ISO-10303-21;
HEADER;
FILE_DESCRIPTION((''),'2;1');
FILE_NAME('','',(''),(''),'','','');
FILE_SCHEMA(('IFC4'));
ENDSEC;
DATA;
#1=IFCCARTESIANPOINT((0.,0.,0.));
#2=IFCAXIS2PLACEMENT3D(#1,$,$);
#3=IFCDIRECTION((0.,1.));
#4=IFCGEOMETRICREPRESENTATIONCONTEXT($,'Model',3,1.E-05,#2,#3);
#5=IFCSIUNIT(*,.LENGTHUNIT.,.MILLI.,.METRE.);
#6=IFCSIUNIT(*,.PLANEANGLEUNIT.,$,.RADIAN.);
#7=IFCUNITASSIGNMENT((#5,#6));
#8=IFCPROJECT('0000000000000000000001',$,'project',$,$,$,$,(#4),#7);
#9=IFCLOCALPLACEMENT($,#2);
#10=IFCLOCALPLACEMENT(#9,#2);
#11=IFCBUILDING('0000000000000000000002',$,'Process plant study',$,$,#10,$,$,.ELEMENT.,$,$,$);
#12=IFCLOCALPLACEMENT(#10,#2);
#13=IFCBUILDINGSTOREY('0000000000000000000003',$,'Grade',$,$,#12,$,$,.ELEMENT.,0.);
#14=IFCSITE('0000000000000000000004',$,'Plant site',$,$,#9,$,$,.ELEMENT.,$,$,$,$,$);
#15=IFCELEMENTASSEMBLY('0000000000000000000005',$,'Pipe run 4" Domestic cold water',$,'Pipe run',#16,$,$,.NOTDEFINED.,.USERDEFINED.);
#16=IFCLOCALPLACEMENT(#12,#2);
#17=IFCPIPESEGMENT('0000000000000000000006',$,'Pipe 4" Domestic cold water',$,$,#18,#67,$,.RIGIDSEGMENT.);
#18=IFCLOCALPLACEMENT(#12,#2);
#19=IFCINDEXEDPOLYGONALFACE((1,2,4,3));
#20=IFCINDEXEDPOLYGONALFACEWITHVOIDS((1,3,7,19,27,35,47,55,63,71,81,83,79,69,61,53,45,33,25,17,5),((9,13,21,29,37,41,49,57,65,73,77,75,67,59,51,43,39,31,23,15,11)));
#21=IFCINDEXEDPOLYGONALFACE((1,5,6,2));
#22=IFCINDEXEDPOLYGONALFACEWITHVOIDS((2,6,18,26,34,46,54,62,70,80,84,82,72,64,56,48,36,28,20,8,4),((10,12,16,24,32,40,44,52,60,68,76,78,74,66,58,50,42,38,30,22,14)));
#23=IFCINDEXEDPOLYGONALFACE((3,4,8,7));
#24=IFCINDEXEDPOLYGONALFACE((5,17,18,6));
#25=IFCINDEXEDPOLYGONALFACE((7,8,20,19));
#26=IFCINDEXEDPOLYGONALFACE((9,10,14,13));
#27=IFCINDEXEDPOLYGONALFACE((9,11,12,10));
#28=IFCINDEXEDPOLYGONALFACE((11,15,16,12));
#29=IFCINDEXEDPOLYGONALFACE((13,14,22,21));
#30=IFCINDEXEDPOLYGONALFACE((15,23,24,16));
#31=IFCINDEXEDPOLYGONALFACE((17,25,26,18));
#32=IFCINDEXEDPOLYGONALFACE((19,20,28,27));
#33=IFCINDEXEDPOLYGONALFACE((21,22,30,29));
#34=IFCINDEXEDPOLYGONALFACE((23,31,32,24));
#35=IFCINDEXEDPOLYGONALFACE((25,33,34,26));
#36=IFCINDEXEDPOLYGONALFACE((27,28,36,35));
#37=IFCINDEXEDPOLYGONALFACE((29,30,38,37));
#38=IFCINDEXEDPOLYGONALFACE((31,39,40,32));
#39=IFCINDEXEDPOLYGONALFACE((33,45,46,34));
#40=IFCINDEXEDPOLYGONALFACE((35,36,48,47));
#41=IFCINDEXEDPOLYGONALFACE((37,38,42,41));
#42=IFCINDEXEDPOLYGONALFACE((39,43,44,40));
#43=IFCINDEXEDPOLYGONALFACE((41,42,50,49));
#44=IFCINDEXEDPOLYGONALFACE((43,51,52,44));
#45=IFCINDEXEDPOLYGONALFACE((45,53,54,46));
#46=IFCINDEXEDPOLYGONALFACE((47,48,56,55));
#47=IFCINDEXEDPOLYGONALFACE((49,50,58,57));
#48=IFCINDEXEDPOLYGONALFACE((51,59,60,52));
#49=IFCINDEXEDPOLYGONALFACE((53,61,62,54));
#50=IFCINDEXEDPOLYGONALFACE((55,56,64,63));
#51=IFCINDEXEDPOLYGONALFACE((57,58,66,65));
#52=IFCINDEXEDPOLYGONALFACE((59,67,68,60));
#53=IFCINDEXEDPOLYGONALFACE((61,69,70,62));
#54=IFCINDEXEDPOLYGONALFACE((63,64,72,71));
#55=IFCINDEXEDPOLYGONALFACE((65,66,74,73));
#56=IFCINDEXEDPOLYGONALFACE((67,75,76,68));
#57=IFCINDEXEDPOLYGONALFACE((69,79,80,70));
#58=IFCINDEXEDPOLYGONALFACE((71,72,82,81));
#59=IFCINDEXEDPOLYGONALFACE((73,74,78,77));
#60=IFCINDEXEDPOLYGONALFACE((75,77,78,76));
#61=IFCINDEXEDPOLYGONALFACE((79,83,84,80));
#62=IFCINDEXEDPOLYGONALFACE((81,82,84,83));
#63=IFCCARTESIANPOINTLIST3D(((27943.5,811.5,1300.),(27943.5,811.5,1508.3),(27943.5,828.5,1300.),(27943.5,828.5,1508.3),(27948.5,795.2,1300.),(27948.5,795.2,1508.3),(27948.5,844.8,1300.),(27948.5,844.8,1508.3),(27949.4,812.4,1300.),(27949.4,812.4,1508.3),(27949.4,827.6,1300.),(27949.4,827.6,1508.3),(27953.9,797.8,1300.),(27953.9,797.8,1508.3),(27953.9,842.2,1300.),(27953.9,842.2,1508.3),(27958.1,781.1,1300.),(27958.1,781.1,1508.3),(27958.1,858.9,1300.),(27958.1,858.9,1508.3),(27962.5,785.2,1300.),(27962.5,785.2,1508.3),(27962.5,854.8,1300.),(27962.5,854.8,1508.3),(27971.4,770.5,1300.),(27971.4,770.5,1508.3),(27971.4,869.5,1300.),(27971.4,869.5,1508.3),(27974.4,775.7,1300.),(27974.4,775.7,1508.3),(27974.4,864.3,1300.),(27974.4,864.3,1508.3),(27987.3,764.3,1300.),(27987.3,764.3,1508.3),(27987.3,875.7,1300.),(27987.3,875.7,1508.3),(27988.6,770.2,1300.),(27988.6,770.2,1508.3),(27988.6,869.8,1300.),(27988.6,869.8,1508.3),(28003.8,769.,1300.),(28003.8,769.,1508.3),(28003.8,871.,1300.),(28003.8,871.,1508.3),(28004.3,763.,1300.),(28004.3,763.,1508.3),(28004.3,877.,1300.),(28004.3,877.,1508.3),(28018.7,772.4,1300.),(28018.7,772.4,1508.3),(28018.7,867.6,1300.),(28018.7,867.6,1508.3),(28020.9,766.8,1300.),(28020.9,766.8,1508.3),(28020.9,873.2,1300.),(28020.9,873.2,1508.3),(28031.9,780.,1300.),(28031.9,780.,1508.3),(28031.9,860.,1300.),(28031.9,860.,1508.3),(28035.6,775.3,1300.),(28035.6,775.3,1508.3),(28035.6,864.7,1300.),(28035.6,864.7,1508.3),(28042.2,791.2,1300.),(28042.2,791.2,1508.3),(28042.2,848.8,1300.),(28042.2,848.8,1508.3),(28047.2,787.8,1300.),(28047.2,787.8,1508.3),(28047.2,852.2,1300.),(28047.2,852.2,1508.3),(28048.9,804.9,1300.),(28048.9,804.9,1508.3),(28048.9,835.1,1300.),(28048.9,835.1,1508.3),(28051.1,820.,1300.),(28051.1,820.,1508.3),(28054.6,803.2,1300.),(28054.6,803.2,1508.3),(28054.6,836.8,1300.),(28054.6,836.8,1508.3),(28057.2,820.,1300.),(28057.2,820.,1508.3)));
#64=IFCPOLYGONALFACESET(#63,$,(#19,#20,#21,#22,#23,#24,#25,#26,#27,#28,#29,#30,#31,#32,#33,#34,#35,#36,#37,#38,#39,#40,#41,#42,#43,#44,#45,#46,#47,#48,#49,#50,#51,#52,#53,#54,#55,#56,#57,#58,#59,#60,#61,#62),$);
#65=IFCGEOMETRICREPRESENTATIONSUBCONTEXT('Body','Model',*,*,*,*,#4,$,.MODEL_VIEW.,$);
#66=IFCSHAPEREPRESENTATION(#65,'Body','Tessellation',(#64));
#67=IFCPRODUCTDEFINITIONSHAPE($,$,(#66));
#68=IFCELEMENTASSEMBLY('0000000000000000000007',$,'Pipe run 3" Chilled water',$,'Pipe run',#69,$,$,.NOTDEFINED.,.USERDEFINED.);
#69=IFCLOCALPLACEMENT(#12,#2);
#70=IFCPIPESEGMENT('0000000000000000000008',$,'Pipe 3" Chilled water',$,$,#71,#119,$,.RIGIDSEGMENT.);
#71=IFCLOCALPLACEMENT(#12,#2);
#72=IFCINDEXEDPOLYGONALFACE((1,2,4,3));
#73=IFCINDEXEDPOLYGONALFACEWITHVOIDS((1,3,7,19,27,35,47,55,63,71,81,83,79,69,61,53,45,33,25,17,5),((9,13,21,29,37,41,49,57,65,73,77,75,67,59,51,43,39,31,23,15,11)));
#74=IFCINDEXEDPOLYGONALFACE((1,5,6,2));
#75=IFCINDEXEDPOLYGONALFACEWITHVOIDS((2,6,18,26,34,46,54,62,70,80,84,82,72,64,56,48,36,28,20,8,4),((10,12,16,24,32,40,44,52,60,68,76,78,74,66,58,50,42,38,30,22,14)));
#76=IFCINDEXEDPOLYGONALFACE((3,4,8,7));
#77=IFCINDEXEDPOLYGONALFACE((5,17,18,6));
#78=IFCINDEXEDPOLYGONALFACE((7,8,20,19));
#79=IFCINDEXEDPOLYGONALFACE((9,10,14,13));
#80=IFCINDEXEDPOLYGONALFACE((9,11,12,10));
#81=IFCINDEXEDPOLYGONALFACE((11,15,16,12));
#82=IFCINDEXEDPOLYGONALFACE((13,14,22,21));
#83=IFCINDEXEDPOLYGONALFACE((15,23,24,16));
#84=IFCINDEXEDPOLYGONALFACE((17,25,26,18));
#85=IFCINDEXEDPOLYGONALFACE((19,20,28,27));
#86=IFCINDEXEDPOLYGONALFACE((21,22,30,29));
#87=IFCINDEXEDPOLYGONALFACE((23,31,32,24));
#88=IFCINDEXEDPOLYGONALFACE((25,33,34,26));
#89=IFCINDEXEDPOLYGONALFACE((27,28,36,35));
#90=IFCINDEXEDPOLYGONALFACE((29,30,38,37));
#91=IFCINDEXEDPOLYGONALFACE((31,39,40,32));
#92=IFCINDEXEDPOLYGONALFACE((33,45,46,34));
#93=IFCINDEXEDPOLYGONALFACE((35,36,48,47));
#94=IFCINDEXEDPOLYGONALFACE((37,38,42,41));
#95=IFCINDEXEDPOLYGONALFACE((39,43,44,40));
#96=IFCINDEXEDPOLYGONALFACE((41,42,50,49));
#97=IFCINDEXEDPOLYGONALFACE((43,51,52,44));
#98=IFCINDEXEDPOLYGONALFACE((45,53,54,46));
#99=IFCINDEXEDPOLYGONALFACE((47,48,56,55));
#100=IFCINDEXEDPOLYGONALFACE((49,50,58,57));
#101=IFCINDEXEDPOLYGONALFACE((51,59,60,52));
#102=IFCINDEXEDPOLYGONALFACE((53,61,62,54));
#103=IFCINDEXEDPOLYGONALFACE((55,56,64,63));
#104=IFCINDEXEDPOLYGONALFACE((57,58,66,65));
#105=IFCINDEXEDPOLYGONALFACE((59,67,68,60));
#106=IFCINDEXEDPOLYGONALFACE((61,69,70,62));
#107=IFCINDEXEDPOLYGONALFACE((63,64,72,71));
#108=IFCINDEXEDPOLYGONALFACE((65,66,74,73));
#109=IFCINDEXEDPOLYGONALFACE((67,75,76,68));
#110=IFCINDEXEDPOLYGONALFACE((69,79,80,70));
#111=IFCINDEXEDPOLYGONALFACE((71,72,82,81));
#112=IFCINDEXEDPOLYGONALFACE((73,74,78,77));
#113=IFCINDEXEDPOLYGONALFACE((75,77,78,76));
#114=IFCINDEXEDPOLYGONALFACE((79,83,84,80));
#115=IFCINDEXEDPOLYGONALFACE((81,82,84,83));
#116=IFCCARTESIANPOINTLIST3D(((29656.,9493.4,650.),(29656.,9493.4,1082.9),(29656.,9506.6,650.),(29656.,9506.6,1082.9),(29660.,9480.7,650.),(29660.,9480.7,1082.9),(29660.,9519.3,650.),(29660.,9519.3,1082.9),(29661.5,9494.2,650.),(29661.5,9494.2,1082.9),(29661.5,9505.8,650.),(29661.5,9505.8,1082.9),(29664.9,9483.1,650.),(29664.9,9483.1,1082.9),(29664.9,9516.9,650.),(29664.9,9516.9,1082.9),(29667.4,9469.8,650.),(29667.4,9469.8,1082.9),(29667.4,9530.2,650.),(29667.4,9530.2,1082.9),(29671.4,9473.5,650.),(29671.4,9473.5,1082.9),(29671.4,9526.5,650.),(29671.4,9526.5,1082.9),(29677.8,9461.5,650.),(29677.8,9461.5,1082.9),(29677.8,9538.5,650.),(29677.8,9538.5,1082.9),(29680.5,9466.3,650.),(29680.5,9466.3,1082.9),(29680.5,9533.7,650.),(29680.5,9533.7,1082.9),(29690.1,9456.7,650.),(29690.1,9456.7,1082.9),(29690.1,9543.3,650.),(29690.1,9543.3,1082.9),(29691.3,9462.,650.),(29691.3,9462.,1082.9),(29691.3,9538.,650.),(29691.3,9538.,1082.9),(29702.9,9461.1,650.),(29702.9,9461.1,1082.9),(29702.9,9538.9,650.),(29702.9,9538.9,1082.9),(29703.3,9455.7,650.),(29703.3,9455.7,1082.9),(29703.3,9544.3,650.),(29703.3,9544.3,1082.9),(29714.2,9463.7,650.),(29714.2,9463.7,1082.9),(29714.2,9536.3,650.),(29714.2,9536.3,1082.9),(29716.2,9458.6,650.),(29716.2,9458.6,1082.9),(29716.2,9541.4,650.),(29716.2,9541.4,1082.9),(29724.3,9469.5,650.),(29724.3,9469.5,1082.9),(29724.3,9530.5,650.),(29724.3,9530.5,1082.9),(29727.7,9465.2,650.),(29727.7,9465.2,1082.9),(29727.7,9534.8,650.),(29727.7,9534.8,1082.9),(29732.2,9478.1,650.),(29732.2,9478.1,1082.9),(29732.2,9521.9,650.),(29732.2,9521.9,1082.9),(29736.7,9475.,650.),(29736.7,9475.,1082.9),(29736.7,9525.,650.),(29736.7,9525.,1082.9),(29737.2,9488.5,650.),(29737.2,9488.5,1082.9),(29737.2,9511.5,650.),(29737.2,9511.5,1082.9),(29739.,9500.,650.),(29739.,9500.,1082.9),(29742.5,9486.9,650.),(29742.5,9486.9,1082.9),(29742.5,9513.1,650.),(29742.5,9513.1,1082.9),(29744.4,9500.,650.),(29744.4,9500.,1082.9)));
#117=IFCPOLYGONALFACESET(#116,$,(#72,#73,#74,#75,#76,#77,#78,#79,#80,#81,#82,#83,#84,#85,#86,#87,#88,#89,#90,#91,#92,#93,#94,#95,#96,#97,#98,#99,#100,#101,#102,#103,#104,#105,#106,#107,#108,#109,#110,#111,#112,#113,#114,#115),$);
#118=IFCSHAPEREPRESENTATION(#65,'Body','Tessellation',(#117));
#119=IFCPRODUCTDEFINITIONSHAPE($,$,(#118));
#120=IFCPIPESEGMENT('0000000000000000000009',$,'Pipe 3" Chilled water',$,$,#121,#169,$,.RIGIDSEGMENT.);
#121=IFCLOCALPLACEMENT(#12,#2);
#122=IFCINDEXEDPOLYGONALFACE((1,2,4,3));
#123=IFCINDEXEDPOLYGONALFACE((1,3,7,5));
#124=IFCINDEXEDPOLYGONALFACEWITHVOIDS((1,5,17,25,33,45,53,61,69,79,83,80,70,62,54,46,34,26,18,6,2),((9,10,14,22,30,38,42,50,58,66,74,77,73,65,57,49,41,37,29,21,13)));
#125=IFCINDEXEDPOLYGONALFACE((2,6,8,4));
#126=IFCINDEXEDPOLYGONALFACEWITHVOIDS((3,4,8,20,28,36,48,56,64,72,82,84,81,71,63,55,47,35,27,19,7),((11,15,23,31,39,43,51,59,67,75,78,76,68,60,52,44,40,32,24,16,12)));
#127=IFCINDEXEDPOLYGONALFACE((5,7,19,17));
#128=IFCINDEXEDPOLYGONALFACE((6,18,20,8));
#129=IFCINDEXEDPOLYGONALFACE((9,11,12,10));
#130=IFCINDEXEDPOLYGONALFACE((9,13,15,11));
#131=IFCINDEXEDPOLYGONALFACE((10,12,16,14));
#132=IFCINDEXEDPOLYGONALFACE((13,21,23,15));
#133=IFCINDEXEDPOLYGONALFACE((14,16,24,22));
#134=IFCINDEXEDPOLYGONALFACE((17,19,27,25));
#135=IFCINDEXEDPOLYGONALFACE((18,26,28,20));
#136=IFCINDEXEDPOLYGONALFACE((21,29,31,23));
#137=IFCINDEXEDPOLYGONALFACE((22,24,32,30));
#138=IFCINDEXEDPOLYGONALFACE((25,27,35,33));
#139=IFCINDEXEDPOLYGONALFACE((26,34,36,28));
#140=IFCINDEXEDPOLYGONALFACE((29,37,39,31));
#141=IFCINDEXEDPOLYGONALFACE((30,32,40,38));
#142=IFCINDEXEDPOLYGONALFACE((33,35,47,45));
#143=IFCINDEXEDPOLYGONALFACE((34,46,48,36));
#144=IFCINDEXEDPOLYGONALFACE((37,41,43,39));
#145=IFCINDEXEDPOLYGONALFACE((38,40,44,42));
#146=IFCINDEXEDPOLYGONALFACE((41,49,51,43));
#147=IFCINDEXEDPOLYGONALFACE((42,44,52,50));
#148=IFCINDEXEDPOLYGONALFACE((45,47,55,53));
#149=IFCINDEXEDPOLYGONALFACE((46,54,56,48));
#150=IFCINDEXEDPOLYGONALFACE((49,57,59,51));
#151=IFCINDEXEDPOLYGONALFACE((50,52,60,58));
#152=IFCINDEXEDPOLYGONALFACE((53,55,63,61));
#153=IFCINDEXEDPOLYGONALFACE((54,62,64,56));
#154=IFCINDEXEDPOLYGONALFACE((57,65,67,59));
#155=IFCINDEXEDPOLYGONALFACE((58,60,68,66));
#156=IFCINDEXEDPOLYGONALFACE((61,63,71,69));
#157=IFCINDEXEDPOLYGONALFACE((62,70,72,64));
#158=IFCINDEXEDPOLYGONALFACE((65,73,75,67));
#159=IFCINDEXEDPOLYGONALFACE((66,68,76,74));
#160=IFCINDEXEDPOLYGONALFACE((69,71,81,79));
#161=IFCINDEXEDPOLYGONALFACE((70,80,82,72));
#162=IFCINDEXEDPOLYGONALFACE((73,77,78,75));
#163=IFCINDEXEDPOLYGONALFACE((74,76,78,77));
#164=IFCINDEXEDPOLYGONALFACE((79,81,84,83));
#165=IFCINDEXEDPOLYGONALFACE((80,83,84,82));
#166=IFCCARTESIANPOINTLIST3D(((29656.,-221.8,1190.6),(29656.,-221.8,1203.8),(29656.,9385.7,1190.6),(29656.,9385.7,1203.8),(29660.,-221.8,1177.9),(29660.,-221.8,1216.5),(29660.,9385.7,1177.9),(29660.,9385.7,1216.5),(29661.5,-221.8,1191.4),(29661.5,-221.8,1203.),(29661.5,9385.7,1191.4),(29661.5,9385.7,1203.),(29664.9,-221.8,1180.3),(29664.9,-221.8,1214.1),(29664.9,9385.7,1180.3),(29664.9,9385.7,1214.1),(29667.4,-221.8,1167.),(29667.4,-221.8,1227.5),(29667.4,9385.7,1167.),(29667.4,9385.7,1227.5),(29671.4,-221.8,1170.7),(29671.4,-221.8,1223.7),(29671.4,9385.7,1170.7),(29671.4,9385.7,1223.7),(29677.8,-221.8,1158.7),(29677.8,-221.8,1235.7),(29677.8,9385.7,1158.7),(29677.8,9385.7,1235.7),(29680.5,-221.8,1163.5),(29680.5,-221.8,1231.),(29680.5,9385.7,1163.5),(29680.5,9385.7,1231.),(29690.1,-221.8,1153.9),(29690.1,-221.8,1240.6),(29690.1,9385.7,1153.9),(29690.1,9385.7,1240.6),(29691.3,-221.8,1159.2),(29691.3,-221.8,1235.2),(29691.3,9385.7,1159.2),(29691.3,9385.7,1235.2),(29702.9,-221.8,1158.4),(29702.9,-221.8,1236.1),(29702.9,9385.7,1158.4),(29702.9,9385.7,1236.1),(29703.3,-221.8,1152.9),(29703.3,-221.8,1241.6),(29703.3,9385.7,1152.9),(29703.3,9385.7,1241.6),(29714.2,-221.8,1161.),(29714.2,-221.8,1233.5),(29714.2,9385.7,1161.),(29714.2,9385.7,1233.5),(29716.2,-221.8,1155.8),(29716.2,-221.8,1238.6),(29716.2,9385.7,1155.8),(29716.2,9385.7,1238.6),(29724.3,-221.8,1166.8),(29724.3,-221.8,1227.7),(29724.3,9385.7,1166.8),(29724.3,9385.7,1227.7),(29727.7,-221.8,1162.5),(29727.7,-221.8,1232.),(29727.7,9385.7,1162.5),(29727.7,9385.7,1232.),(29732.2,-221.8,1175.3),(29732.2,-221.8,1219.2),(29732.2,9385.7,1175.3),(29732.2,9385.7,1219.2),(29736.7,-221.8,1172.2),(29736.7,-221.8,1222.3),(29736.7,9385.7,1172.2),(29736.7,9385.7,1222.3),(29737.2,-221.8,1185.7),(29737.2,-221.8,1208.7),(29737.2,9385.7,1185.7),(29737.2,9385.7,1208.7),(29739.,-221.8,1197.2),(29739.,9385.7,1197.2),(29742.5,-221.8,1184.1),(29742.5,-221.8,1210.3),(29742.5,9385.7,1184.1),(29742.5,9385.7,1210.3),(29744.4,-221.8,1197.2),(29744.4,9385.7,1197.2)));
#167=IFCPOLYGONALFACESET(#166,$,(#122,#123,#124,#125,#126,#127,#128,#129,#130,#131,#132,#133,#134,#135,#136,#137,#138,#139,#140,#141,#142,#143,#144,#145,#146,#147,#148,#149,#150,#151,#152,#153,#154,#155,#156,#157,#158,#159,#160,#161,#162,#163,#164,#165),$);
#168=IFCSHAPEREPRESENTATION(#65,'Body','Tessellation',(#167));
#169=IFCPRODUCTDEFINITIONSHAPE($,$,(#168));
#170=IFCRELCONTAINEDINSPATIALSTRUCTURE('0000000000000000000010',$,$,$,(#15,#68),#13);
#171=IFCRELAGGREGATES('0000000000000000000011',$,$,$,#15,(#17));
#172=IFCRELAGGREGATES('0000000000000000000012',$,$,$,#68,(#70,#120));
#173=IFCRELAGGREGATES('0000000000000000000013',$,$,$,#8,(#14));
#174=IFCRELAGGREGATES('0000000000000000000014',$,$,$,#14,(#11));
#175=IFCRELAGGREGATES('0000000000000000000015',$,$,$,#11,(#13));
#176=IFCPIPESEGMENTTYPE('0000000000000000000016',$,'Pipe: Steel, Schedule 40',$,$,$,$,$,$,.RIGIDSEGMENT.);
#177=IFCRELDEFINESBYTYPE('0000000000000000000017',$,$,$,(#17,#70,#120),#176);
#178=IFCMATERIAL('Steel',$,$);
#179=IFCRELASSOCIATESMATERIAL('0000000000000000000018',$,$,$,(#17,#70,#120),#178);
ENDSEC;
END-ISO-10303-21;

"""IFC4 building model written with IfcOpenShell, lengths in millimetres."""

from ifc_helpers import new_model, si_unit, direction, frame, origin, origin_with_axes, origin_2d, place, context, subcontext, project, spatial, hollow_circle, extrude, material, type_object, element, aggregate, save


model = new_model("IFC4")

# Units and contexts
model_context = context("Model", 3, precision=1e-05, world=origin(), true_north=direction((0.0, 1.0)))
body_context = subcontext(model_context, "Body", "Model", "MODEL_VIEW")
ifc_project = project(units=[si_unit("LENGTHUNIT", "METRE", prefix="MILLI"), si_unit("PLANEANGLEUNIT", "RADIAN")], contexts=[model_context])

# Site, building, storey
site_placement = place(None, origin())
site = spatial("IfcSite", under=ifc_project, at=site_placement, Name="Plant site", CompositionType="ELEMENT")
building_placement = place(site_placement, origin())
building = spatial("IfcBuilding", under=site, at=building_placement, Name="Process plant study", CompositionType="ELEMENT")
storey_placement = place(building_placement, origin())
storey = spatial("IfcBuildingStorey", under=building, at=storey_placement, Name="Grade", CompositionType="ELEMENT", Elevation=0.0)

# Element assembly, pipe segment
assembly_1_placement = place(storey_placement, origin_with_axes())
assembly_1 = element("IfcElementAssembly", 1, at=assembly_1_placement, inside=storey, Name="Pipe run 4\" Domestic cold water", ObjectType="Pipe run", AssemblyPlace="NOTDEFINED", PredefinedType="USERDEFINED")
ifc_material = material(Name="Steel")
pipe_segment_type = type_object("IfcPipeSegmentType", Name="Pipe: Steel, Schedule 40", PredefinedType="RIGIDSEGMENT")
pipe_segment_1_placement = place(storey_placement, origin_with_axes())
pipe_segment_1 = element("IfcPipeSegment", 2, at=pipe_segment_1_placement, type_object=pipe_segment_type, material=ifc_material, Name="Pipe 4\" Domestic cold water", PredefinedType="RIGIDSEGMENT", context=body_context, shape_type="SweptSolid", body=[
    extrude(hollow_circle(Radius=57.1, WallThickness=6.0, at=origin_2d()), frame((28000.0, 820.0, 1508.3), z_axis=(0.0, 0.0, -1.0), x_axis=(1.0, 0.0, 0.0)), (0.0, 0.0, 1.0), 208.3),
])

# Element assembly, pipe segments
assembly_2_placement = place(storey_placement, origin_with_axes())
assembly_2 = element("IfcElementAssembly", 3, at=assembly_2_placement, inside=storey, Name="Pipe run 3\" Chilled water", ObjectType="Pipe run", AssemblyPlace="NOTDEFINED", PredefinedType="USERDEFINED")
pipe_segment_2_placement = place(storey_placement, origin_with_axes())
pipe_segment_2 = element("IfcPipeSegment", 4, at=pipe_segment_2_placement, type_object=pipe_segment_type, material=ifc_material, Name="Pipe 3\" Chilled water", PredefinedType="RIGIDSEGMENT", context=body_context, shape_type="SweptSolid", body=[
    extrude(hollow_circle(Radius=44.5, WallThickness=5.5, at=origin_2d()), frame((29700.0, 9500.0, 650.0), z_axis=(0.0, 0.0, 1.0), x_axis=(1.0, 0.0, 0.0)), (0.0, 0.0, 1.0), 432.9),
])
pipe_segment_3_placement = place(storey_placement, origin_with_axes())
pipe_segment_3 = element("IfcPipeSegment", 5, at=pipe_segment_3_placement, type_object=pipe_segment_type, material=ifc_material, Name="Pipe 3\" Chilled water", PredefinedType="RIGIDSEGMENT", context=body_context, shape_type="SweptSolid", body=[
    extrude(hollow_circle(Radius=44.5, WallThickness=5.5, at=origin_2d()), frame((29700.0, 9385.7, 1197.2), z_axis=(0.0, -1.0, 0.0), x_axis=(1.0, 0.0, 0.0)), (0.0, 0.0, 1.0), 9607.5),
])

aggregate(assembly_1, [pipe_segment_1])
aggregate(assembly_2, [pipe_segment_2, pipe_segment_3])

save(model, "model.ifc")
